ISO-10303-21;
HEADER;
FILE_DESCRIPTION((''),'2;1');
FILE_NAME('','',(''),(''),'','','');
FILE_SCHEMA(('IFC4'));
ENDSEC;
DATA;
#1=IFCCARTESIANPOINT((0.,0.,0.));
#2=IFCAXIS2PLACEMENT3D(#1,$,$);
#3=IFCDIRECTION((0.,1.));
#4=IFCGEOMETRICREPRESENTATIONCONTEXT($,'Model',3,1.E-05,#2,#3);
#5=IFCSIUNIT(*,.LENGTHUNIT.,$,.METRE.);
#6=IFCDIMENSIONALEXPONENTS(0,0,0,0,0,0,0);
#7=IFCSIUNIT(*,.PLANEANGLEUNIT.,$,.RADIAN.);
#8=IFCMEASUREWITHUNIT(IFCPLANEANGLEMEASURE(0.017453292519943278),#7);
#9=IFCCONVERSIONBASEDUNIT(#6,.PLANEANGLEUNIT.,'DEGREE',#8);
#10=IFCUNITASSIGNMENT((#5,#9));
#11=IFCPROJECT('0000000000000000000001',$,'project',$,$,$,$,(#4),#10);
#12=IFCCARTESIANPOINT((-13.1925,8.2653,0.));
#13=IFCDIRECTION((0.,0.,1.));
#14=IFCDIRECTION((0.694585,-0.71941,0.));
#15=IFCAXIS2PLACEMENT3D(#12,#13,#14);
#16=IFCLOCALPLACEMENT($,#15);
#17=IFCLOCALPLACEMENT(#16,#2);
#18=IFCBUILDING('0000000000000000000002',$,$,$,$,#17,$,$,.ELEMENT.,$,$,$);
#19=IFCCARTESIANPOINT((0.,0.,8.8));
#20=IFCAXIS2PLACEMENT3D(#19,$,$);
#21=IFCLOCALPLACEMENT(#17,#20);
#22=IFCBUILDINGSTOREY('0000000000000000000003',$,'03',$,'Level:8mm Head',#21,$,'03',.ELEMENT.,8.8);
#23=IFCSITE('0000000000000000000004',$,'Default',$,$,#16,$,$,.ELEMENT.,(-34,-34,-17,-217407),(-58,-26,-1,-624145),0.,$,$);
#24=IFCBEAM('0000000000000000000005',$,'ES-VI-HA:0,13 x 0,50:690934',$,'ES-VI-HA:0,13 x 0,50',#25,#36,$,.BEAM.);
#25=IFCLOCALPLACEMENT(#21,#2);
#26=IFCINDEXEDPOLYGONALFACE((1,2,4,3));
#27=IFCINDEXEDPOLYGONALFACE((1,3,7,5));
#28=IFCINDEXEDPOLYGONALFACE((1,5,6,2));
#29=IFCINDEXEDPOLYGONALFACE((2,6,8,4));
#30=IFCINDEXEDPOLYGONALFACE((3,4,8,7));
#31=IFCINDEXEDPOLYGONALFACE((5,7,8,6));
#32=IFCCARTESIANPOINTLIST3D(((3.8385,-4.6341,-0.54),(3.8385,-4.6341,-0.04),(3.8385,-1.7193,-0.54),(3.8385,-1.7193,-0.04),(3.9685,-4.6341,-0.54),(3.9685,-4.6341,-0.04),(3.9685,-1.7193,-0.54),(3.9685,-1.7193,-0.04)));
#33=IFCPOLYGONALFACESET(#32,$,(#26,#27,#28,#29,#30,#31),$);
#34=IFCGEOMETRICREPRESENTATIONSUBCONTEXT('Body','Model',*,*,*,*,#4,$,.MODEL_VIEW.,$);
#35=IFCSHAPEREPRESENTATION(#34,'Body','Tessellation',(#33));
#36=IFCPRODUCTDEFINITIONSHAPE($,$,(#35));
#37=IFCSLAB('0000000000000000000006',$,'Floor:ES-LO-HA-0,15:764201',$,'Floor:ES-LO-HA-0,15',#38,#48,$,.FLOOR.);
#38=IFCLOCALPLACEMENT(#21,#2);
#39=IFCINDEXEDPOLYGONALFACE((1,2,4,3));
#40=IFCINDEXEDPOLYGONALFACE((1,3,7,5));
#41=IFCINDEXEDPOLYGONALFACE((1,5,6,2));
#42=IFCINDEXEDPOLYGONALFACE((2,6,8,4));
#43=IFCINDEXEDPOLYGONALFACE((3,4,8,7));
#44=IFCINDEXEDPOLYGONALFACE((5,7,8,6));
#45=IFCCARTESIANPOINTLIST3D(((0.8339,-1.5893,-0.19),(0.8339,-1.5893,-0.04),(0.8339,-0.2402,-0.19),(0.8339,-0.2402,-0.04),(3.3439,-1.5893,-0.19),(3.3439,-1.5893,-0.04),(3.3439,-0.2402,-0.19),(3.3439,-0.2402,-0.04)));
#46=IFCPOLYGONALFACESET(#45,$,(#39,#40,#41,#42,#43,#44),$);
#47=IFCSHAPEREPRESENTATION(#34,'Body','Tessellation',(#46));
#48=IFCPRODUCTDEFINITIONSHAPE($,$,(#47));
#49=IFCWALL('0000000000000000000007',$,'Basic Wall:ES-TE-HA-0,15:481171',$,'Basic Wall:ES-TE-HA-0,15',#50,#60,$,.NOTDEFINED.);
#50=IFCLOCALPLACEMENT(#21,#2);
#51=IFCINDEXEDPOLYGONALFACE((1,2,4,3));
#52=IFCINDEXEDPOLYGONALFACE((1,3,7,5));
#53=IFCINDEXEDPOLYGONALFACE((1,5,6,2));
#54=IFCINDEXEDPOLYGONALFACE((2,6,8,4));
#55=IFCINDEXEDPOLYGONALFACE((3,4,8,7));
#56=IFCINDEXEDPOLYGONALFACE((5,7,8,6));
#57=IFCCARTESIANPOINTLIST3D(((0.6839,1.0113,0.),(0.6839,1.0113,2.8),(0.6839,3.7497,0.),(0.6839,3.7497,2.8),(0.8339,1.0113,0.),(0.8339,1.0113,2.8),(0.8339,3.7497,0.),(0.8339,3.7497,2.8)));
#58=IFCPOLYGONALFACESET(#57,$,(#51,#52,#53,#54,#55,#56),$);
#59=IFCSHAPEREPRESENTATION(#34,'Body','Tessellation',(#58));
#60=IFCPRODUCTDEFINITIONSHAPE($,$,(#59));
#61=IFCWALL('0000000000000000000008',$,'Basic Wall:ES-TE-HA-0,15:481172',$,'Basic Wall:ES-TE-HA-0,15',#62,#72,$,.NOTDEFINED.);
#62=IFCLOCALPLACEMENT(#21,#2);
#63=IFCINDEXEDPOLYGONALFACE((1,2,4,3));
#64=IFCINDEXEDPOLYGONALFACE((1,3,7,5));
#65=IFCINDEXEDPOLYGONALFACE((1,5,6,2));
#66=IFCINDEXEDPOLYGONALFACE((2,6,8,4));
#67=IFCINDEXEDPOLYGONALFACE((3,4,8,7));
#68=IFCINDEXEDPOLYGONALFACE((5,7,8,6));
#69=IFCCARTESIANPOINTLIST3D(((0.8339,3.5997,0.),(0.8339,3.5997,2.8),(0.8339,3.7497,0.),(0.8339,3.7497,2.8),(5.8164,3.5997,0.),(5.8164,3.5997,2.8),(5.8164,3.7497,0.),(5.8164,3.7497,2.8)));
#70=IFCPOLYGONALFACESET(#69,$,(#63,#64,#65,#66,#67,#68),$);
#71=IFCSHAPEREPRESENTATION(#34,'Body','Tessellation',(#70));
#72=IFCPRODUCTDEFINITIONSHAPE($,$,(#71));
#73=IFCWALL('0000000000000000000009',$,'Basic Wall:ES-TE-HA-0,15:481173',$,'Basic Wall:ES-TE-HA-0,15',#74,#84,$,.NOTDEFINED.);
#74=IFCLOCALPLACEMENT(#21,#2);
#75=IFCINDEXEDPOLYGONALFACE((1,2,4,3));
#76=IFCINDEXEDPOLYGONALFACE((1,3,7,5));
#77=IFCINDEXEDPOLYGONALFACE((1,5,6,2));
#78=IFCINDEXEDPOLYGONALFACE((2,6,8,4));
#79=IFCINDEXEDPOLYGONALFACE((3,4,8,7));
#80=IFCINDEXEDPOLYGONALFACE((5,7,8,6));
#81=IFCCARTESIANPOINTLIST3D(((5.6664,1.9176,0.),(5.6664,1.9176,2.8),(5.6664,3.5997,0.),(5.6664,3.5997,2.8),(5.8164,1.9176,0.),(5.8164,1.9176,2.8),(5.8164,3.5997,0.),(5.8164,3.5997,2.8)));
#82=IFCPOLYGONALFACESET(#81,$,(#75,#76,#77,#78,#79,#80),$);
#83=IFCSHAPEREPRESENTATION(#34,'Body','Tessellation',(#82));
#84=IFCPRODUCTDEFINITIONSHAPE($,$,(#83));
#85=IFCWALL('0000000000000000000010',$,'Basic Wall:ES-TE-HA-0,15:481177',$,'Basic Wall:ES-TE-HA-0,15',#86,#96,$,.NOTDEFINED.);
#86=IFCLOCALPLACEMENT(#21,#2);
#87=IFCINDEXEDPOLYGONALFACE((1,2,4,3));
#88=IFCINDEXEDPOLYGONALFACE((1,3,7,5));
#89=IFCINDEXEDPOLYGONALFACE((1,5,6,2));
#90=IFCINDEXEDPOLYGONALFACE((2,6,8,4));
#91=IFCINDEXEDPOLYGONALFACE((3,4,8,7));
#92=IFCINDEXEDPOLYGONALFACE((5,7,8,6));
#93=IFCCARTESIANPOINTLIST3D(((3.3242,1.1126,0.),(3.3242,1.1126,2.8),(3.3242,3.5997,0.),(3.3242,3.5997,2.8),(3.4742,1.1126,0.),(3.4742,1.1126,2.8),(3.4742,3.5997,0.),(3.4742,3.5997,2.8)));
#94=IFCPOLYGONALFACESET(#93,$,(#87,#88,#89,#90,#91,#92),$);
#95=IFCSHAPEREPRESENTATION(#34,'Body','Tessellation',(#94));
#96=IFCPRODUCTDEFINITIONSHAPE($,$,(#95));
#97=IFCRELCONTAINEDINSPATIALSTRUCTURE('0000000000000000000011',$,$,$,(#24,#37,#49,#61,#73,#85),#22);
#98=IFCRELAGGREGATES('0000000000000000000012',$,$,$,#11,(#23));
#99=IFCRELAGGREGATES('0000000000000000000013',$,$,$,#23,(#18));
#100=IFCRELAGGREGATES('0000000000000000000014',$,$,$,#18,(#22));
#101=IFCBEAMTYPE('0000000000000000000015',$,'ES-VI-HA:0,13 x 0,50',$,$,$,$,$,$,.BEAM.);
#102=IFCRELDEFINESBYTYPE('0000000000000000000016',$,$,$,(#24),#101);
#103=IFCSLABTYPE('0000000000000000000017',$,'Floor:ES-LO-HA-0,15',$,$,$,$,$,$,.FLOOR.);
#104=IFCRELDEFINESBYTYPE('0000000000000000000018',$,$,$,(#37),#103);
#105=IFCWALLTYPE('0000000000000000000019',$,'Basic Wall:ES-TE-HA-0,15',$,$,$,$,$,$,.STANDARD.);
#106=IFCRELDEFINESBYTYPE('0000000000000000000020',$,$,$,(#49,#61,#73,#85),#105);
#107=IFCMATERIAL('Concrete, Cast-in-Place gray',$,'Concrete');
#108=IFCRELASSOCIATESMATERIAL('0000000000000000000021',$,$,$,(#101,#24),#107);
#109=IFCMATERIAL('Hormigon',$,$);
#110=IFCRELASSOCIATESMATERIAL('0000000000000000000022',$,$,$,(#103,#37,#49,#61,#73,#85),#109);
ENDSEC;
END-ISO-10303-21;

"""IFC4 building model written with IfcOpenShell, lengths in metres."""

from ifc_helpers import new_model, entity, si_unit, converted_unit, direction, frame, origin, place, context, subcontext, project, spatial, indexed_curve, outline, extrude, source, transform, mapped, material, type_object, type_shapes, element, save


model = new_model("IFC4")

# Units and contexts
model_context = context("Model", 3, precision=1e-05, world=origin(), true_north=direction((0.0, 1.0)))
body_context = subcontext(model_context, "Body", "Model", "MODEL_VIEW")
ifc_project = project(units=[si_unit("LENGTHUNIT", "METRE"), converted_unit("PLANEANGLEUNIT", "DEGREE", entity("IfcPlaneAngleMeasure", 0.017453292519943278), si_unit("PLANEANGLEUNIT", "RADIAN"), dimensions=[0, 0, 0, 0, 0, 0, 0])], contexts=[model_context])

# Site, building, storey
site_placement = place(None, frame((-13.1925, 8.2653, 0.0), z_axis=(0.0, 0.0, 1.0), x_axis=(0.694585, -0.71941, 0.0)))
site = spatial("IfcSite", under=ifc_project, at=site_placement, Name="Default", CompositionType="ELEMENT", RefLatitude=(-34, -34, -17, -217407), RefLongitude=(-58, -26, -1, -624145), RefElevation=0.0)
building_placement = place(site_placement, origin())
building = spatial("IfcBuilding", under=site, at=building_placement, CompositionType="ELEMENT")
storey_placement = place(building_placement, frame((0.0, 0.0, 8.8)))
storey = spatial("IfcBuildingStorey", under=building, at=storey_placement, Name="03", ObjectType="Level:8mm Head", LongName="03", CompositionType="ELEMENT", Elevation=8.8)

# Beam
ifc_material_1 = material(Name="Concrete, Cast-in-Place gray", Category="Concrete")
beam_type = type_object("IfcBeamType", Name="ES-VI-HA:0,13 x 0,50", PredefinedType="BEAM", material=ifc_material_1)
shared_shape = source(origin(), body_context, "Body", "SweptSolid", [
    extrude(outline(indexed_curve([(-0.065, -0.25), (0.065, -0.25), (0.065, 0.25), (-0.065, 0.25), (-0.065, -0.25)], self_intersect=False)), frame((3.9035, -4.6341, 8.51), z_axis=(0.0, 1.0, 0.0), x_axis=(-1.0, 0.0, 0.0)), (0.0, 0.0, 1.0), 2.9148),
])
type_shapes(beam_type, [shared_shape])
beam_placement = place(storey_placement, frame((0.0, 0.0, -8.8)))
element("IfcBeam", 1, at=beam_placement, inside=storey, type_object=beam_type, material=ifc_material_1, Name="ES-VI-HA:0,13 x 0,50:690934", ObjectType="ES-VI-HA:0,13 x 0,50", PredefinedType="BEAM", context=body_context, shape_type="MappedRepresentation", body=[
    mapped(shared_shape, transform((0.0, 0.0, 0.0), scale=1.0)),
])

# Shared definitions
ifc_material_2 = material(Name="Hormigon")
slab_type_1 = type_object("IfcSlabType", Name="Floor:ES-LO-HA-0,15", PredefinedType="FLOOR", material=ifc_material_2)

# Slab
slab_1_placement = place(storey_placement, origin())
element("IfcSlab", 2, at=slab_1_placement, inside=storey, type_object=slab_type_1, material=ifc_material_2, Name="Floor:ES-LO-HA-0,15:764201", ObjectType="Floor:ES-LO-HA-0,15", PredefinedType="FLOOR", context=body_context, shape_type="SweptSolid", body=[
    extrude(outline(indexed_curve([(-0.6746, -1.255), (0.6746, -1.255), (0.6746, 1.255), (-0.6746, 1.255), (-0.6746, -1.255)], self_intersect=False)), frame((2.0889, -0.9147, -0.04), z_axis=(0.0, 0.0, -1.0), x_axis=(0.0, 1.0, 0.0)), (0.0, 0.0, 1.0), 0.15),
])

# Walls
wall_type = type_object("IfcWallType", Name="Basic Wall:ES-TE-HA-0,15", PredefinedType="STANDARD")
wall_1_placement = place(storey_placement, frame((0.7589, 1.0113, 0.0), z_axis=(0.0, 0.0, 1.0), x_axis=(0.0, 1.0, 0.0)))
element("IfcWall", 3, at=wall_1_placement, inside=storey, type_object=wall_type, material=ifc_material_2, Name="Basic Wall:ES-TE-HA-0,15:481171", ObjectType="Basic Wall:ES-TE-HA-0,15", PredefinedType="NOTDEFINED", context=body_context, shape_type="SweptSolid", body=[
    extrude(outline(indexed_curve([(2.7384, 0.075), (0.0, 0.075), (0.0, -0.075), (2.7384, -0.075), (2.7384, 0.075)], self_intersect=False)), origin(), (0.0, 0.0, 1.0), 2.8),
])
wall_2_placement = place(storey_placement, frame((0.8339, 3.6747, 0.0)))
element("IfcWall", 4, at=wall_2_placement, inside=storey, type_object=wall_type, material=ifc_material_2, Name="Basic Wall:ES-TE-HA-0,15:481172", ObjectType="Basic Wall:ES-TE-HA-0,15", PredefinedType="NOTDEFINED", context=body_context, shape_type="SweptSolid", body=[
    extrude(outline(indexed_curve([(4.9825, 0.075), (0.0, 0.075), (0.0, -0.075), (4.9825, -0.075), (4.9825, 0.075)], self_intersect=False)), origin(), (0.0, 0.0, 1.0), 2.8),
])
wall_3_placement = place(storey_placement, frame((5.7414, 1.9176, 0.0), z_axis=(0.0, 0.0, 1.0), x_axis=(0.0, 1.0, 0.0)))
element("IfcWall", 5, at=wall_3_placement, inside=storey, type_object=wall_type, material=ifc_material_2, Name="Basic Wall:ES-TE-HA-0,15:481173", ObjectType="Basic Wall:ES-TE-HA-0,15", PredefinedType="NOTDEFINED", context=body_context, shape_type="SweptSolid", body=[
    extrude(outline(indexed_curve([(1.682, 0.075), (0.0, 0.075), (0.0, -0.075), (1.682, -0.075), (1.682, 0.075)], self_intersect=False)), origin(), (0.0, 0.0, 1.0), 2.8),
])
wall_4_placement = place(storey_placement, frame((3.3992, 3.5997, 0.0), z_axis=(0.0, 0.0, 1.0), x_axis=(0.0, -1.0, 0.0)))
element("IfcWall", 6, at=wall_4_placement, inside=storey, type_object=wall_type, material=ifc_material_2, Name="Basic Wall:ES-TE-HA-0,15:481177", ObjectType="Basic Wall:ES-TE-HA-0,15", PredefinedType="NOTDEFINED", context=body_context, shape_type="SweptSolid", body=[
    extrude(outline(indexed_curve([(2.487, 0.075), (0.0, 0.075), (0.0, -0.075), (2.487, -0.075), (2.487, 0.075)], self_intersect=False)), origin(), (0.0, 0.0, 1.0), 2.8),
])

save(model, "model.ifc")
